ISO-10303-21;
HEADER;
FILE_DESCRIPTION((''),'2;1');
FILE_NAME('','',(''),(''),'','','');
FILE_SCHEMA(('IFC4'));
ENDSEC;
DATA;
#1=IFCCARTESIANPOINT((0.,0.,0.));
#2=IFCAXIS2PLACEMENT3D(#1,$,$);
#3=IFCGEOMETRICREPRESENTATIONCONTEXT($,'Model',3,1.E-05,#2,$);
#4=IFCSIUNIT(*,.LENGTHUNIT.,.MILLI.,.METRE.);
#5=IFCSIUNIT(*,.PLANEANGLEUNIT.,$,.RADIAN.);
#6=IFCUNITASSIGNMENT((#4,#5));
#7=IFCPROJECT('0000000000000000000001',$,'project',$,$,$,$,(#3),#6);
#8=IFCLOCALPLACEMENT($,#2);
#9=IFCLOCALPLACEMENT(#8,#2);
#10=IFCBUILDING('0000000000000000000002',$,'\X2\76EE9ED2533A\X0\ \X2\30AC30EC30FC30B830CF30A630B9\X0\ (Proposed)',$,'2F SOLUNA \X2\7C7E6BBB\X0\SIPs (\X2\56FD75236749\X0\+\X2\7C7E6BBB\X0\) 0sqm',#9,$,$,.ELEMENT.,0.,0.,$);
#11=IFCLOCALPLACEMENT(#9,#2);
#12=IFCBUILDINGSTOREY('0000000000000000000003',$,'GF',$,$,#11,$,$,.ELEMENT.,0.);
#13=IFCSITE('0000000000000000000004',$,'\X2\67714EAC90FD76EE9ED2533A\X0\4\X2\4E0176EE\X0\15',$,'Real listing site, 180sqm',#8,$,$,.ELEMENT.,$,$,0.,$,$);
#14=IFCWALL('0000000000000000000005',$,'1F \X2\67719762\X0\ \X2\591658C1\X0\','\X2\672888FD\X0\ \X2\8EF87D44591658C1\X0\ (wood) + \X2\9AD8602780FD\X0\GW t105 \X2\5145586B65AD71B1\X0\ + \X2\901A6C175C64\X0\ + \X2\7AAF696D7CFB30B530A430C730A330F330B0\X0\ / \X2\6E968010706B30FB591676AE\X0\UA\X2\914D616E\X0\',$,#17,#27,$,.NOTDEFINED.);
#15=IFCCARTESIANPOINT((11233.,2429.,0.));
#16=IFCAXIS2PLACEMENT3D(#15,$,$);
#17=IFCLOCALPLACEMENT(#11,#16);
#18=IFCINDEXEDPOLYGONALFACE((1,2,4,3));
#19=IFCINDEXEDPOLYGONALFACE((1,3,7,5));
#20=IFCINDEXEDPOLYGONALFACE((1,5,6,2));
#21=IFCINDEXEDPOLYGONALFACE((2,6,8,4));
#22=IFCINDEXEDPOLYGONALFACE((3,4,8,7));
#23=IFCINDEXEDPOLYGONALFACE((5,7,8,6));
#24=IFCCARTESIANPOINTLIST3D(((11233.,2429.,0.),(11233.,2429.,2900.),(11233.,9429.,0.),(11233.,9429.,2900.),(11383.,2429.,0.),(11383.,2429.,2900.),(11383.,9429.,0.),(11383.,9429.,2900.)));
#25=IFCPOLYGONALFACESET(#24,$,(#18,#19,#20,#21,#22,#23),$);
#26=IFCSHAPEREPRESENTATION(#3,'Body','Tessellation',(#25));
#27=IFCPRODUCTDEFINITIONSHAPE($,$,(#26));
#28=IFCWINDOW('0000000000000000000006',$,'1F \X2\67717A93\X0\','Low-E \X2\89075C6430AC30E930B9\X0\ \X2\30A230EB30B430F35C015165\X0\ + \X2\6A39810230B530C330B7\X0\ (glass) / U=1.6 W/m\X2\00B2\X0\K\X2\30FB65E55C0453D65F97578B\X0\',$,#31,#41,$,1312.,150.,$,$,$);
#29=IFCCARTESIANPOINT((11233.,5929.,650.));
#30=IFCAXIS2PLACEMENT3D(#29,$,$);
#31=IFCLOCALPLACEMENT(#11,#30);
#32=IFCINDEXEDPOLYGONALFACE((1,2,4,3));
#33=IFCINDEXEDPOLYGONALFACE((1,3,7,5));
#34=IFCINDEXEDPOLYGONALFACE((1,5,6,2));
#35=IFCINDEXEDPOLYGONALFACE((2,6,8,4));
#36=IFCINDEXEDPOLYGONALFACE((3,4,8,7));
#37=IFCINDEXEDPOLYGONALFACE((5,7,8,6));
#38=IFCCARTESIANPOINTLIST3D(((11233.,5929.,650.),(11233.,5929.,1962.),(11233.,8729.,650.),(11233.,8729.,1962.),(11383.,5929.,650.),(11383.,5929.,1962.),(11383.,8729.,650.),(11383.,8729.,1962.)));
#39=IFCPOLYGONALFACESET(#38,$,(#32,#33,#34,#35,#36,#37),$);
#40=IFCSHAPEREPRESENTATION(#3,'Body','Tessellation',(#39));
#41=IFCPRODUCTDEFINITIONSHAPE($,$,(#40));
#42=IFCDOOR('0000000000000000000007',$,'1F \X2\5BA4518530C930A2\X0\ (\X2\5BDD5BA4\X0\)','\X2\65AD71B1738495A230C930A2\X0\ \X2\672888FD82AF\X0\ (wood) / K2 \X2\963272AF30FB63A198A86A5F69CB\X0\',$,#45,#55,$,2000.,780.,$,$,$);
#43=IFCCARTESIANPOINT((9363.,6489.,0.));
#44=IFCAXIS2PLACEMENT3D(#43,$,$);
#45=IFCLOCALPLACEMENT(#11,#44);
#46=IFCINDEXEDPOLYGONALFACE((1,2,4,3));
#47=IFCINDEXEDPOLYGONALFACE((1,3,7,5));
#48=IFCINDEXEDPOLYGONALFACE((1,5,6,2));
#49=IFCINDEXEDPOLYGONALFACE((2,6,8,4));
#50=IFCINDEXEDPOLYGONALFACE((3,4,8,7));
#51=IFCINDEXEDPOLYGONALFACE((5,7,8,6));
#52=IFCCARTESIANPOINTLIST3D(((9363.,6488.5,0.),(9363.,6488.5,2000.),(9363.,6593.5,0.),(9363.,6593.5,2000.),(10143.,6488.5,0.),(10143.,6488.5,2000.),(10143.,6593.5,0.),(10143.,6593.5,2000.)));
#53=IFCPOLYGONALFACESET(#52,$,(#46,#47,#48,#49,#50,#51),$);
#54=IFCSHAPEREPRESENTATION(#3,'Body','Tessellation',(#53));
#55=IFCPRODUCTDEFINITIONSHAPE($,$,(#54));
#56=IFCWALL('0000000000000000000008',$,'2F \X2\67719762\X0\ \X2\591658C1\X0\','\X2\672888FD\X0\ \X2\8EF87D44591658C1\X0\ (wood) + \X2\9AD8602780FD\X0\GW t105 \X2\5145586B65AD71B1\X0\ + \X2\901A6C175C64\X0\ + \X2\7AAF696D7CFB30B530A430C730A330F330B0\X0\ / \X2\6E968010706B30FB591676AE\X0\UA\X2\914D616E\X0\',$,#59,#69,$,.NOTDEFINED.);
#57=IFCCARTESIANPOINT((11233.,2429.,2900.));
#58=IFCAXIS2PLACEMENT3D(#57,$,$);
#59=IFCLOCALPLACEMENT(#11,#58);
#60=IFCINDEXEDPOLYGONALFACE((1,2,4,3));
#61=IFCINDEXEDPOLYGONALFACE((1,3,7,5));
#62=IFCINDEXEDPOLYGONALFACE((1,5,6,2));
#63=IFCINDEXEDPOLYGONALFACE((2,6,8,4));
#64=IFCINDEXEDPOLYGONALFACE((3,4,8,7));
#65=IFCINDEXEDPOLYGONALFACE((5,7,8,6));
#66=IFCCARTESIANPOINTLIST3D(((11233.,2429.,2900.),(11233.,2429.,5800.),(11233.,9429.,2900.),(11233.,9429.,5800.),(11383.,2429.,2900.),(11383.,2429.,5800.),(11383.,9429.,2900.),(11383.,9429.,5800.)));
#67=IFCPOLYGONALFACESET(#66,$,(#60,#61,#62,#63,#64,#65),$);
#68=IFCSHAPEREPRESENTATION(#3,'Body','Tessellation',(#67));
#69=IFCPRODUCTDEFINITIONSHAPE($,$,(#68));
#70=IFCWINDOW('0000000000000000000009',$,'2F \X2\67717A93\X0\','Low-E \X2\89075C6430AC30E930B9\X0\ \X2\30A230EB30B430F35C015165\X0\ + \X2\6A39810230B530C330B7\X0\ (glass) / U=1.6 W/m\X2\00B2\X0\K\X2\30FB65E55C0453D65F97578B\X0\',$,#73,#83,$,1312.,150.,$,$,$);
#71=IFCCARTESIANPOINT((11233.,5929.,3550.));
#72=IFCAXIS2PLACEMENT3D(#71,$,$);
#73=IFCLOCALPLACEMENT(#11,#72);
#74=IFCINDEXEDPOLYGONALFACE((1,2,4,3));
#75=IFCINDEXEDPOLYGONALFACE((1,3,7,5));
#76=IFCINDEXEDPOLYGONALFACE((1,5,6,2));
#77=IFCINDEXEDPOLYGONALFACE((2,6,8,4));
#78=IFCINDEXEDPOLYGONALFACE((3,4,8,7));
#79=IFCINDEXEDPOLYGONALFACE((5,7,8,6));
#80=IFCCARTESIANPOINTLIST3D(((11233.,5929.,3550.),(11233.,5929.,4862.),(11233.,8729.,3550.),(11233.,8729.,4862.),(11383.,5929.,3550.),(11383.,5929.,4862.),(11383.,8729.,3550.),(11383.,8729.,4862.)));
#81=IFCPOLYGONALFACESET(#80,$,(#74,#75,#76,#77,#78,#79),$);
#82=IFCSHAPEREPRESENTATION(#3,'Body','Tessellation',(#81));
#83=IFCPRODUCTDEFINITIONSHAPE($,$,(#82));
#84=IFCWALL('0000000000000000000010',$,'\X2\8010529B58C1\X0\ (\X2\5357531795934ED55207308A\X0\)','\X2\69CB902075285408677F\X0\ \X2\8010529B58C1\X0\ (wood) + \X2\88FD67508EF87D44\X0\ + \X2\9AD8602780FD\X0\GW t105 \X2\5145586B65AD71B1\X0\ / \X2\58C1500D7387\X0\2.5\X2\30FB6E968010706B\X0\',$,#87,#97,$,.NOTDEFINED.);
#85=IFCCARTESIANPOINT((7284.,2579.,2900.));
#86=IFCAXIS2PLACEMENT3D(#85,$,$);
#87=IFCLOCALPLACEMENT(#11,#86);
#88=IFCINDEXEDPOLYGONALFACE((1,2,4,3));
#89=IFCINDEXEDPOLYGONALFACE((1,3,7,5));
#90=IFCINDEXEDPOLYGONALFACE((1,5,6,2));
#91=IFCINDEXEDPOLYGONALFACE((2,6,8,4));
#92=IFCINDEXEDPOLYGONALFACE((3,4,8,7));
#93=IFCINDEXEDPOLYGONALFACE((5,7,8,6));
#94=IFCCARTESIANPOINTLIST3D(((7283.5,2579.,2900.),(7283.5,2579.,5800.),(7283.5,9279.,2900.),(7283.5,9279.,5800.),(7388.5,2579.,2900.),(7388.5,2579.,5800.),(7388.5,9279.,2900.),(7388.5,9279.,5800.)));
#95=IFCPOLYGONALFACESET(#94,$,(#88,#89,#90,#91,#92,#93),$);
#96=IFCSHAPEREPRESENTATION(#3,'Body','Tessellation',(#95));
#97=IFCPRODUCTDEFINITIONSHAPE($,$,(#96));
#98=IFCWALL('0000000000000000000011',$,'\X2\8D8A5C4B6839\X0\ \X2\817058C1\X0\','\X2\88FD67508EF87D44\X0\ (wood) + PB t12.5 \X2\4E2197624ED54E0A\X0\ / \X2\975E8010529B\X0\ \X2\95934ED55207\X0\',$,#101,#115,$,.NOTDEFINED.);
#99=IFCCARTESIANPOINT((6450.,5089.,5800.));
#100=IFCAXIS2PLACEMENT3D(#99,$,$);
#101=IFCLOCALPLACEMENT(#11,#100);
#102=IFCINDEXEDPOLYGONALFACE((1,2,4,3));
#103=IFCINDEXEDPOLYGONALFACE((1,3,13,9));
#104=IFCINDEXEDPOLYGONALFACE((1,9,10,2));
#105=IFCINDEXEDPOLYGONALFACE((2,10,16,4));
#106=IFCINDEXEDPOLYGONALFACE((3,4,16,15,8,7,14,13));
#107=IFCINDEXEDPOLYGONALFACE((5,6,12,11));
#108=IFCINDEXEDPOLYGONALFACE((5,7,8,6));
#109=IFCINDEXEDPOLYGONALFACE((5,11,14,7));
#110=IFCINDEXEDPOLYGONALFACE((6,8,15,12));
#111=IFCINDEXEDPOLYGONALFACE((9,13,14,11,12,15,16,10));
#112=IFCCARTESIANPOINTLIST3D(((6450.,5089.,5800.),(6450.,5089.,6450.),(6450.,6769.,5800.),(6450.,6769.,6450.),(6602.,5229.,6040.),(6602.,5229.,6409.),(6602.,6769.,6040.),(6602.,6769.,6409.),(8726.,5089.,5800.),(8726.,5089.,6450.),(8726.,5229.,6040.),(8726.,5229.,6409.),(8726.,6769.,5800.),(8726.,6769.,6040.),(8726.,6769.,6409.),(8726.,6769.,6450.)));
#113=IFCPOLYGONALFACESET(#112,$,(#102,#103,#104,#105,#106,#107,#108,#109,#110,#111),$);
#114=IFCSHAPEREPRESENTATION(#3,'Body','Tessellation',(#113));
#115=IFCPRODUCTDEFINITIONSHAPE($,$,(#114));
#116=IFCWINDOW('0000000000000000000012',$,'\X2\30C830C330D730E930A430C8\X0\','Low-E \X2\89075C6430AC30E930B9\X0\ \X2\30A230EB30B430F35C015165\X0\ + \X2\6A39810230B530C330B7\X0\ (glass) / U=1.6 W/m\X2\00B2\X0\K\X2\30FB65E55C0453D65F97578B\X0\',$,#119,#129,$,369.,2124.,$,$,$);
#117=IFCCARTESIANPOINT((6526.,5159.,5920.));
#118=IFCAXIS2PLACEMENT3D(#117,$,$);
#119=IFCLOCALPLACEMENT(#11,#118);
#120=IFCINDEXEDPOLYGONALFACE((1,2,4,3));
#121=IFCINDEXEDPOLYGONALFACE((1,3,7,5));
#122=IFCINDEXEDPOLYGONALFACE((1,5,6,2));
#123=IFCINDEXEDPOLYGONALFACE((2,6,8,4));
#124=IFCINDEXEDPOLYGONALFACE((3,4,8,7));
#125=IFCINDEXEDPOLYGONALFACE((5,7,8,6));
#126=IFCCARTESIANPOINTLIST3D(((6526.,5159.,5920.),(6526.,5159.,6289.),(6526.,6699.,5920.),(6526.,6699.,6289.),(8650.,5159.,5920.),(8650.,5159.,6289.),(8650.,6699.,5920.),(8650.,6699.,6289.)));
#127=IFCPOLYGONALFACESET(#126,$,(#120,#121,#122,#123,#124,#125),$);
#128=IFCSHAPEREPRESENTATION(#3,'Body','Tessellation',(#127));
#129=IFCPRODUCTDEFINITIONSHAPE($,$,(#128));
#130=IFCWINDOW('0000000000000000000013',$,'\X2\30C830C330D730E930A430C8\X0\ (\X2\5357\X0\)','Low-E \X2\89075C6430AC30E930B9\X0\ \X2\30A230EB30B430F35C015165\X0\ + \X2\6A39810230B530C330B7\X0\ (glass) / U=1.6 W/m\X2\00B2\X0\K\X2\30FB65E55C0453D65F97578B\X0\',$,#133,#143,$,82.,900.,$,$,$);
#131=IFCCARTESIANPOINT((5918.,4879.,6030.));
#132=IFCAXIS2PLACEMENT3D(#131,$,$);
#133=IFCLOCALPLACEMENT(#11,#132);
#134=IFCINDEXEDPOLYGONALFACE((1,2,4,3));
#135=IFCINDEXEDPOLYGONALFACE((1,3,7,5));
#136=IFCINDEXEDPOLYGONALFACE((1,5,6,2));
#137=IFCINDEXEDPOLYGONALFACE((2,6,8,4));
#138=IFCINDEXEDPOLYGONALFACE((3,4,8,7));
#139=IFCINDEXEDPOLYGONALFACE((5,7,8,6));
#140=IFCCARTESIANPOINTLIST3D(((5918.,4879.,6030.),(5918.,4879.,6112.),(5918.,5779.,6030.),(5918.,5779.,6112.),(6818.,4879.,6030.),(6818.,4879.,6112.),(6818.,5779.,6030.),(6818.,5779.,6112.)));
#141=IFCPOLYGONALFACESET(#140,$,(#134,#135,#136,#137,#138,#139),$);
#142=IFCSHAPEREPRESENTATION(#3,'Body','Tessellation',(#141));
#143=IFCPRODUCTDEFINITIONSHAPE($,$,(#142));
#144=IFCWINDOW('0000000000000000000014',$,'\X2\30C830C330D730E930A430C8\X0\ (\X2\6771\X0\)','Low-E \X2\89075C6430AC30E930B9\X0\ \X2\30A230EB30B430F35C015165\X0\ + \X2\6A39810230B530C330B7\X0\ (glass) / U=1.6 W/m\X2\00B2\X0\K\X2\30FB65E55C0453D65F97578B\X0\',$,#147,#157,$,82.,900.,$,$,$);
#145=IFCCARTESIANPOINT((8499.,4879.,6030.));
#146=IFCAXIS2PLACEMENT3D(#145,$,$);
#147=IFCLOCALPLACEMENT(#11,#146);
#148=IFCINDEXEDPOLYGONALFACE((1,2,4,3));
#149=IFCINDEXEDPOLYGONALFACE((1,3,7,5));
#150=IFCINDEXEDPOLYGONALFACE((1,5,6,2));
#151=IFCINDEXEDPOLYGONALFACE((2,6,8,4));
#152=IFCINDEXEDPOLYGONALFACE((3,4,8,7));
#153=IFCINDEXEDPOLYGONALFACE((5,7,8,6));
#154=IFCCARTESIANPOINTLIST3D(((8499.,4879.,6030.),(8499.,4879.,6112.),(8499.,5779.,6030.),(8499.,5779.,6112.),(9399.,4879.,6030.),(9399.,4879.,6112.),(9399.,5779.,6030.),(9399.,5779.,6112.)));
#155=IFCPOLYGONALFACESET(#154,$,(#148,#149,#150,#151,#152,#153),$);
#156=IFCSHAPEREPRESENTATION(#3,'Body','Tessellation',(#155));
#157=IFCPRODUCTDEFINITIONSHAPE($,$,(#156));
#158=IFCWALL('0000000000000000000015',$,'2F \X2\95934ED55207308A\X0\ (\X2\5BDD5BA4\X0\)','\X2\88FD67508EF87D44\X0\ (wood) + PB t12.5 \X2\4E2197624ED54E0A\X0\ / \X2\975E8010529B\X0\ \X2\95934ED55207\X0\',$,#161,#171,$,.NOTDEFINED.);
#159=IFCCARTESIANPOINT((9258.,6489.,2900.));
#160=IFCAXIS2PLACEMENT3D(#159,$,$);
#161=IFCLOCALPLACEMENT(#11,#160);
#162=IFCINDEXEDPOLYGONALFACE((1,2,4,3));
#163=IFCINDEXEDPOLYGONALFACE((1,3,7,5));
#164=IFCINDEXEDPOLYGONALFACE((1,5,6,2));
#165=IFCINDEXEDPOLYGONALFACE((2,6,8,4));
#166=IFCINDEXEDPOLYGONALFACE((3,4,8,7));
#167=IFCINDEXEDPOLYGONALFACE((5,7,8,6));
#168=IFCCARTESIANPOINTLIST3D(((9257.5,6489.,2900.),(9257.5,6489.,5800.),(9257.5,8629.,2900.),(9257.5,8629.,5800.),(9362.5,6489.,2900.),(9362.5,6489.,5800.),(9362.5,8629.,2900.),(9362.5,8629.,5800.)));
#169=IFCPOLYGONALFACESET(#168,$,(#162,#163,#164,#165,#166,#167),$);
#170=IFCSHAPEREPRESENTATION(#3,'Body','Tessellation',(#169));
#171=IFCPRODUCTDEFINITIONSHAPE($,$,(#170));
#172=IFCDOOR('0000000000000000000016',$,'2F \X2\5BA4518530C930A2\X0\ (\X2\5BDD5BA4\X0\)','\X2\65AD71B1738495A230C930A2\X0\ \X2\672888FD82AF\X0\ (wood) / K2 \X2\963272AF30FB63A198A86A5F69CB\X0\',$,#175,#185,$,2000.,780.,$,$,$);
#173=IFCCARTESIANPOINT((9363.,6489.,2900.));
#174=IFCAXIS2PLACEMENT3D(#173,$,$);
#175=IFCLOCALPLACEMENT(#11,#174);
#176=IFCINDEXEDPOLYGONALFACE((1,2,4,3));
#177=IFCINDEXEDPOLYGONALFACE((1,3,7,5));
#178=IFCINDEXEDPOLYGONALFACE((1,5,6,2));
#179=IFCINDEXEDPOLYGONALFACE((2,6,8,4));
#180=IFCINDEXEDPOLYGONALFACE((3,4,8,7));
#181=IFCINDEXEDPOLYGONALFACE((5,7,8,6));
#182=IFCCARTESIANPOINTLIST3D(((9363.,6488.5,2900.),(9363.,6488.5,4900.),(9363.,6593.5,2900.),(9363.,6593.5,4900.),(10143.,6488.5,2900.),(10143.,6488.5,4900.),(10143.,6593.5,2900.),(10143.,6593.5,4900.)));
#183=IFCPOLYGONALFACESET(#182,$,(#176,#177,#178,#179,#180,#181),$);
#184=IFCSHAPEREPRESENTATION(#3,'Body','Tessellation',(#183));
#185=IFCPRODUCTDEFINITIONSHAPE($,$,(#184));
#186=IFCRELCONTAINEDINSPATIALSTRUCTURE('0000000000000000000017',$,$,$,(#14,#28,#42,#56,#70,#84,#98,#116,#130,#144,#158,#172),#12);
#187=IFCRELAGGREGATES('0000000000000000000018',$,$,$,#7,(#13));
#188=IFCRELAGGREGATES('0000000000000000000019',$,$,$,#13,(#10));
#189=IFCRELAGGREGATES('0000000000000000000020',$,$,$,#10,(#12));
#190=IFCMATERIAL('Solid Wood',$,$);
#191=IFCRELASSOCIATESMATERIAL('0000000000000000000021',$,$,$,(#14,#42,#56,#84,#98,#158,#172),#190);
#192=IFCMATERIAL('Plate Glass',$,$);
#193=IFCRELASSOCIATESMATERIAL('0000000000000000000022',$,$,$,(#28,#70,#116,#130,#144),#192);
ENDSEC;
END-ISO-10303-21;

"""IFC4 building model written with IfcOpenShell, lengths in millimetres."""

from ifc_helpers import new_model, si_unit, frame, frame_2d, origin, place, context, project, spatial, rectangle, extrude, material, element, fill, save


model = new_model("IFC4")

# Units and contexts
model_context = context("Model", 3, precision=1e-05, world=origin())
ifc_project = project(units=[si_unit("LENGTHUNIT", "METRE", prefix="MILLI"), si_unit("PLANEANGLEUNIT", "RADIAN")], contexts=[model_context])

# Site, building, storey
site_placement = place(None, origin())
site = spatial("IfcSite", under=ifc_project, at=site_placement, Name="東京都目黒区4丁目15", ObjectType="Real listing site, 180sqm", CompositionType="ELEMENT", RefElevation=0.0)
building_placement = place(site_placement, origin())
building = spatial("IfcBuilding", under=site, at=building_placement, Name="目黒区 ガレージハウス (Proposed)", ObjectType="2F SOLUNA 籾殻SIPs (国産杉+籾殻) 0sqm", CompositionType="ELEMENT", ElevationOfRefHeight=0.0, ElevationOfTerrain=0.0)
storey_placement = place(building_placement, origin())
storey = spatial("IfcBuildingStorey", under=building, at=storey_placement, Name="GF", CompositionType="ELEMENT", Elevation=0.0)

# Wall, opening, window
ifc_material_1 = material(Name="Solid Wood")
wall_1_placement = place(storey_placement, frame((11233.0, 2429.0, 0.0)))
wall_1 = element("IfcWall", 1, at=wall_1_placement, inside=storey, material=ifc_material_1, Name="1F 東面 外壁", Description="木製 軸組外壁 (wood) + 高性能GW t105 充填断熱 + 通気層 + 窯業系サイディング / 準耐火・外皮UA配慮", PredefinedType="NOTDEFINED", context=model_context, shape_type="SweptSolid", body=[
    extrude(rectangle(XDim=150.0, YDim=7000.0, at=frame_2d((75.0, 3500.0))), frame((11233.0, 2429.0, 0.0)), (0.0, 0.0, 1.0), 2900.0),
])
opening_1_placement = place(storey_placement, frame((11233.0, 5929.0, 650.0)))
opening_1 = element("IfcOpeningElement", 2, at=opening_1_placement, cuts=wall_1, PredefinedType="NOTDEFINED", context=model_context, shape_type="SweptSolid", body=[
    extrude(rectangle(XDim=150.0, YDim=2800.0, at=frame_2d((75.0, 1400.0))), frame((11233.0, 5929.0, 650.0)), (0.0, 0.0, 1.0), 1312.0),
])
ifc_material_2 = material(Name="Plate Glass")
window_1_placement = place(storey_placement, frame((11233.0, 5929.0, 650.0)))
window_1 = element("IfcWindow", 3, at=window_1_placement, inside=storey, material=ifc_material_2, Name="1F 東窓", Description="Low-E 複層ガラス アルゴン封入 + 樹脂サッシ (glass) / U=1.6 W/m²K・日射取得型", OverallHeight=1312.0, OverallWidth=150.0, context=model_context, shape_type="SweptSolid", body=[
    extrude(rectangle(XDim=150.0, YDim=2800.0, at=frame_2d((75.0, 1400.0))), frame((11233.0, 5929.0, 650.0)), (0.0, 0.0, 1.0), 1312.0),
])
fill(opening_1, window_1)

# Door
door_1_placement = place(storey_placement, frame((9363.0, 6489.0, 0.0)))
element("IfcDoor", 4, at=door_1_placement, inside=storey, material=ifc_material_1, Name="1F 室内ドア (寝室)", Description="断熱玄関ドア 木製芯 (wood) / K2 防犯・採風機構", OverallHeight=2000.0, OverallWidth=780.0, context=model_context, shape_type="SweptSolid", body=[
    extrude(rectangle(XDim=780.0, YDim=105.0, at=frame_2d((390.0, 52.0))), frame((9363.0, 6489.0, 0.0)), (0.0, 0.0, 1.0), 2000.0),
])

# Wall, opening, window
wall_2_placement = place(storey_placement, frame((11233.0, 2429.0, 2900.0)))
wall_2 = element("IfcWall", 5, at=wall_2_placement, inside=storey, material=ifc_material_1, Name="2F 東面 外壁", Description="木製 軸組外壁 (wood) + 高性能GW t105 充填断熱 + 通気層 + 窯業系サイディング / 準耐火・外皮UA配慮", PredefinedType="NOTDEFINED", context=model_context, shape_type="SweptSolid", body=[
    extrude(rectangle(XDim=150.0, YDim=7000.0, at=frame_2d((75.0, 3500.0))), frame((11233.0, 2429.0, 2900.0)), (0.0, 0.0, 1.0), 2900.0),
])
opening_2_placement = place(storey_placement, frame((11233.0, 5929.0, 3550.0)))
opening_2 = element("IfcOpeningElement", 6, at=opening_2_placement, cuts=wall_2, PredefinedType="NOTDEFINED", context=model_context, shape_type="SweptSolid", body=[
    extrude(rectangle(XDim=150.0, YDim=2800.0, at=frame_2d((75.0, 1400.0))), frame((11233.0, 5929.0, 3550.0)), (0.0, 0.0, 1.0), 1312.0),
])
window_2_placement = place(storey_placement, frame((11233.0, 5929.0, 3550.0)))
window_2 = element("IfcWindow", 7, at=window_2_placement, inside=storey, material=ifc_material_2, Name="2F 東窓", Description="Low-E 複層ガラス アルゴン封入 + 樹脂サッシ (glass) / U=1.6 W/m²K・日射取得型", OverallHeight=1312.0, OverallWidth=150.0, context=model_context, shape_type="SweptSolid", body=[
    extrude(rectangle(XDim=150.0, YDim=2800.0, at=frame_2d((75.0, 1400.0))), frame((11233.0, 5929.0, 3550.0)), (0.0, 0.0, 1.0), 1312.0),
])
fill(opening_2, window_2)

# Wall
wall_3_placement = place(storey_placement, frame((7284.0, 2579.0, 2900.0)))
element("IfcWall", 8, at=wall_3_placement, inside=storey, material=ifc_material_1, Name="耐力壁 (南北間仕切り)", Description="構造用合板 耐力壁 (wood) + 製材軸組 + 高性能GW t105 充填断熱 / 壁倍率2.5・準耐火", PredefinedType="NOTDEFINED", context=model_context, shape_type="SweptSolid", body=[
    extrude(rectangle(XDim=105.0, YDim=6700.0, at=frame_2d((52.0, 3350.0))), frame((7284.0, 2579.0, 2900.0)), (0.0, 0.0, 1.0), 2900.0),
])

# Wall, openings, windows
wall_4_placement = place(storey_placement, frame((6450.0, 5089.0, 5800.0)))
wall_4 = element("IfcWall", 9, at=wall_4_placement, inside=storey, material=ifc_material_1, Name="越屋根 腰壁", Description="製材軸組 (wood) + PB t12.5 両面仕上 / 非耐力 間仕切", PredefinedType="NOTDEFINED", context=model_context, shape_type="SweptSolid", body=[
    extrude(rectangle(XDim=2276.0, YDim=1680.0, at=frame_2d((1138.0, 840.0))), frame((6450.0, 5089.0, 5800.0)), (0.0, 0.0, 1.0), 650.0),
])
opening_3_placement = place(storey_placement, frame((6526.0, 5159.0, 5920.0)))
opening_3 = element("IfcOpeningElement", 10, at=opening_3_placement, cuts=wall_4, PredefinedType="NOTDEFINED", context=model_context, shape_type="SweptSolid", body=[
    extrude(rectangle(XDim=2124.0, YDim=1540.0, at=frame_2d((1062.0, 770.0))), frame((6526.0, 5159.0, 5920.0)), (0.0, 0.0, 1.0), 369.0),
])
opening_4_placement = place(storey_placement, frame((5918.0, 4879.0, 6030.0)))
opening_4 = element("IfcOpeningElement", 11, at=opening_4_placement, cuts=wall_4, PredefinedType="NOTDEFINED", context=model_context, shape_type="SweptSolid", body=[
    extrude(rectangle(XDim=900.0, YDim=900.0, at=frame_2d((450.0, 450.0))), frame((5918.0, 4879.0, 6030.0)), (0.0, 0.0, 1.0), 82.0),
])
opening_5_placement = place(storey_placement, frame((8499.0, 4879.0, 6030.0)))
opening_5 = element("IfcOpeningElement", 12, at=opening_5_placement, cuts=wall_4, PredefinedType="NOTDEFINED", context=model_context, shape_type="SweptSolid", body=[
    extrude(rectangle(XDim=900.0, YDim=900.0, at=frame_2d((450.0, 450.0))), frame((8499.0, 4879.0, 6030.0)), (0.0, 0.0, 1.0), 82.0),
])
window_3_placement = place(storey_placement, frame((6526.0, 5159.0, 5920.0)))
window_3 = element("IfcWindow", 13, at=window_3_placement, inside=storey, material=ifc_material_2, Name="トップライト", Description="Low-E 複層ガラス アルゴン封入 + 樹脂サッシ (glass) / U=1.6 W/m²K・日射取得型", OverallHeight=369.0, OverallWidth=2124.0, context=model_context, shape_type="SweptSolid", body=[
    extrude(rectangle(XDim=2124.0, YDim=1540.0, at=frame_2d((1062.0, 770.0))), frame((6526.0, 5159.0, 5920.0)), (0.0, 0.0, 1.0), 369.0),
])
fill(opening_3, window_3)
window_4_placement = place(storey_placement, frame((5918.0, 4879.0, 6030.0)))
window_4 = element("IfcWindow", 14, at=window_4_placement, inside=storey, material=ifc_material_2, Name="トップライト (南)", Description="Low-E 複層ガラス アルゴン封入 + 樹脂サッシ (glass) / U=1.6 W/m²K・日射取得型", OverallHeight=82.0, OverallWidth=900.0, context=model_context, shape_type="SweptSolid", body=[
    extrude(rectangle(XDim=900.0, YDim=900.0, at=frame_2d((450.0, 450.0))), frame((5918.0, 4879.0, 6030.0)), (0.0, 0.0, 1.0), 82.0),
])
fill(opening_4, window_4)
window_5_placement = place(storey_placement, frame((8499.0, 4879.0, 6030.0)))
window_5 = element("IfcWindow", 15, at=window_5_placement, inside=storey, material=ifc_material_2, Name="トップライト (東)", Description="Low-E 複層ガラス アルゴン封入 + 樹脂サッシ (glass) / U=1.6 W/m²K・日射取得型", OverallHeight=82.0, OverallWidth=900.0, context=model_context, shape_type="SweptSolid", body=[
    extrude(rectangle(XDim=900.0, YDim=900.0, at=frame_2d((450.0, 450.0))), frame((8499.0, 4879.0, 6030.0)), (0.0, 0.0, 1.0), 82.0),
])
fill(opening_5, window_5)

# Wall
wall_5_placement = place(storey_placement, frame((9258.0, 6489.0, 2900.0)))
element("IfcWall", 16, at=wall_5_placement, inside=storey, material=ifc_material_1, Name="2F 間仕切り (寝室)", Description="製材軸組 (wood) + PB t12.5 両面仕上 / 非耐力 間仕切", PredefinedType="NOTDEFINED", context=model_context, shape_type="SweptSolid", body=[
    extrude(rectangle(XDim=105.0, YDim=2140.0, at=frame_2d((52.0, 1070.0))), frame((9258.0, 6489.0, 2900.0)), (0.0, 0.0, 1.0), 2900.0),
])

# Door
door_2_placement = place(storey_placement, frame((9363.0, 6489.0, 2900.0)))
element("IfcDoor", 17, at=door_2_placement, inside=storey, material=ifc_material_1, Name="2F 室内ドア (寝室)", Description="断熱玄関ドア 木製芯 (wood) / K2 防犯・採風機構", OverallHeight=2000.0, OverallWidth=780.0, context=model_context, shape_type="SweptSolid", body=[
    extrude(rectangle(XDim=780.0, YDim=105.0, at=frame_2d((390.0, 52.0))), frame((9363.0, 6489.0, 2900.0)), (0.0, 0.0, 1.0), 2000.0),
])

save(model, "model.ifc")
